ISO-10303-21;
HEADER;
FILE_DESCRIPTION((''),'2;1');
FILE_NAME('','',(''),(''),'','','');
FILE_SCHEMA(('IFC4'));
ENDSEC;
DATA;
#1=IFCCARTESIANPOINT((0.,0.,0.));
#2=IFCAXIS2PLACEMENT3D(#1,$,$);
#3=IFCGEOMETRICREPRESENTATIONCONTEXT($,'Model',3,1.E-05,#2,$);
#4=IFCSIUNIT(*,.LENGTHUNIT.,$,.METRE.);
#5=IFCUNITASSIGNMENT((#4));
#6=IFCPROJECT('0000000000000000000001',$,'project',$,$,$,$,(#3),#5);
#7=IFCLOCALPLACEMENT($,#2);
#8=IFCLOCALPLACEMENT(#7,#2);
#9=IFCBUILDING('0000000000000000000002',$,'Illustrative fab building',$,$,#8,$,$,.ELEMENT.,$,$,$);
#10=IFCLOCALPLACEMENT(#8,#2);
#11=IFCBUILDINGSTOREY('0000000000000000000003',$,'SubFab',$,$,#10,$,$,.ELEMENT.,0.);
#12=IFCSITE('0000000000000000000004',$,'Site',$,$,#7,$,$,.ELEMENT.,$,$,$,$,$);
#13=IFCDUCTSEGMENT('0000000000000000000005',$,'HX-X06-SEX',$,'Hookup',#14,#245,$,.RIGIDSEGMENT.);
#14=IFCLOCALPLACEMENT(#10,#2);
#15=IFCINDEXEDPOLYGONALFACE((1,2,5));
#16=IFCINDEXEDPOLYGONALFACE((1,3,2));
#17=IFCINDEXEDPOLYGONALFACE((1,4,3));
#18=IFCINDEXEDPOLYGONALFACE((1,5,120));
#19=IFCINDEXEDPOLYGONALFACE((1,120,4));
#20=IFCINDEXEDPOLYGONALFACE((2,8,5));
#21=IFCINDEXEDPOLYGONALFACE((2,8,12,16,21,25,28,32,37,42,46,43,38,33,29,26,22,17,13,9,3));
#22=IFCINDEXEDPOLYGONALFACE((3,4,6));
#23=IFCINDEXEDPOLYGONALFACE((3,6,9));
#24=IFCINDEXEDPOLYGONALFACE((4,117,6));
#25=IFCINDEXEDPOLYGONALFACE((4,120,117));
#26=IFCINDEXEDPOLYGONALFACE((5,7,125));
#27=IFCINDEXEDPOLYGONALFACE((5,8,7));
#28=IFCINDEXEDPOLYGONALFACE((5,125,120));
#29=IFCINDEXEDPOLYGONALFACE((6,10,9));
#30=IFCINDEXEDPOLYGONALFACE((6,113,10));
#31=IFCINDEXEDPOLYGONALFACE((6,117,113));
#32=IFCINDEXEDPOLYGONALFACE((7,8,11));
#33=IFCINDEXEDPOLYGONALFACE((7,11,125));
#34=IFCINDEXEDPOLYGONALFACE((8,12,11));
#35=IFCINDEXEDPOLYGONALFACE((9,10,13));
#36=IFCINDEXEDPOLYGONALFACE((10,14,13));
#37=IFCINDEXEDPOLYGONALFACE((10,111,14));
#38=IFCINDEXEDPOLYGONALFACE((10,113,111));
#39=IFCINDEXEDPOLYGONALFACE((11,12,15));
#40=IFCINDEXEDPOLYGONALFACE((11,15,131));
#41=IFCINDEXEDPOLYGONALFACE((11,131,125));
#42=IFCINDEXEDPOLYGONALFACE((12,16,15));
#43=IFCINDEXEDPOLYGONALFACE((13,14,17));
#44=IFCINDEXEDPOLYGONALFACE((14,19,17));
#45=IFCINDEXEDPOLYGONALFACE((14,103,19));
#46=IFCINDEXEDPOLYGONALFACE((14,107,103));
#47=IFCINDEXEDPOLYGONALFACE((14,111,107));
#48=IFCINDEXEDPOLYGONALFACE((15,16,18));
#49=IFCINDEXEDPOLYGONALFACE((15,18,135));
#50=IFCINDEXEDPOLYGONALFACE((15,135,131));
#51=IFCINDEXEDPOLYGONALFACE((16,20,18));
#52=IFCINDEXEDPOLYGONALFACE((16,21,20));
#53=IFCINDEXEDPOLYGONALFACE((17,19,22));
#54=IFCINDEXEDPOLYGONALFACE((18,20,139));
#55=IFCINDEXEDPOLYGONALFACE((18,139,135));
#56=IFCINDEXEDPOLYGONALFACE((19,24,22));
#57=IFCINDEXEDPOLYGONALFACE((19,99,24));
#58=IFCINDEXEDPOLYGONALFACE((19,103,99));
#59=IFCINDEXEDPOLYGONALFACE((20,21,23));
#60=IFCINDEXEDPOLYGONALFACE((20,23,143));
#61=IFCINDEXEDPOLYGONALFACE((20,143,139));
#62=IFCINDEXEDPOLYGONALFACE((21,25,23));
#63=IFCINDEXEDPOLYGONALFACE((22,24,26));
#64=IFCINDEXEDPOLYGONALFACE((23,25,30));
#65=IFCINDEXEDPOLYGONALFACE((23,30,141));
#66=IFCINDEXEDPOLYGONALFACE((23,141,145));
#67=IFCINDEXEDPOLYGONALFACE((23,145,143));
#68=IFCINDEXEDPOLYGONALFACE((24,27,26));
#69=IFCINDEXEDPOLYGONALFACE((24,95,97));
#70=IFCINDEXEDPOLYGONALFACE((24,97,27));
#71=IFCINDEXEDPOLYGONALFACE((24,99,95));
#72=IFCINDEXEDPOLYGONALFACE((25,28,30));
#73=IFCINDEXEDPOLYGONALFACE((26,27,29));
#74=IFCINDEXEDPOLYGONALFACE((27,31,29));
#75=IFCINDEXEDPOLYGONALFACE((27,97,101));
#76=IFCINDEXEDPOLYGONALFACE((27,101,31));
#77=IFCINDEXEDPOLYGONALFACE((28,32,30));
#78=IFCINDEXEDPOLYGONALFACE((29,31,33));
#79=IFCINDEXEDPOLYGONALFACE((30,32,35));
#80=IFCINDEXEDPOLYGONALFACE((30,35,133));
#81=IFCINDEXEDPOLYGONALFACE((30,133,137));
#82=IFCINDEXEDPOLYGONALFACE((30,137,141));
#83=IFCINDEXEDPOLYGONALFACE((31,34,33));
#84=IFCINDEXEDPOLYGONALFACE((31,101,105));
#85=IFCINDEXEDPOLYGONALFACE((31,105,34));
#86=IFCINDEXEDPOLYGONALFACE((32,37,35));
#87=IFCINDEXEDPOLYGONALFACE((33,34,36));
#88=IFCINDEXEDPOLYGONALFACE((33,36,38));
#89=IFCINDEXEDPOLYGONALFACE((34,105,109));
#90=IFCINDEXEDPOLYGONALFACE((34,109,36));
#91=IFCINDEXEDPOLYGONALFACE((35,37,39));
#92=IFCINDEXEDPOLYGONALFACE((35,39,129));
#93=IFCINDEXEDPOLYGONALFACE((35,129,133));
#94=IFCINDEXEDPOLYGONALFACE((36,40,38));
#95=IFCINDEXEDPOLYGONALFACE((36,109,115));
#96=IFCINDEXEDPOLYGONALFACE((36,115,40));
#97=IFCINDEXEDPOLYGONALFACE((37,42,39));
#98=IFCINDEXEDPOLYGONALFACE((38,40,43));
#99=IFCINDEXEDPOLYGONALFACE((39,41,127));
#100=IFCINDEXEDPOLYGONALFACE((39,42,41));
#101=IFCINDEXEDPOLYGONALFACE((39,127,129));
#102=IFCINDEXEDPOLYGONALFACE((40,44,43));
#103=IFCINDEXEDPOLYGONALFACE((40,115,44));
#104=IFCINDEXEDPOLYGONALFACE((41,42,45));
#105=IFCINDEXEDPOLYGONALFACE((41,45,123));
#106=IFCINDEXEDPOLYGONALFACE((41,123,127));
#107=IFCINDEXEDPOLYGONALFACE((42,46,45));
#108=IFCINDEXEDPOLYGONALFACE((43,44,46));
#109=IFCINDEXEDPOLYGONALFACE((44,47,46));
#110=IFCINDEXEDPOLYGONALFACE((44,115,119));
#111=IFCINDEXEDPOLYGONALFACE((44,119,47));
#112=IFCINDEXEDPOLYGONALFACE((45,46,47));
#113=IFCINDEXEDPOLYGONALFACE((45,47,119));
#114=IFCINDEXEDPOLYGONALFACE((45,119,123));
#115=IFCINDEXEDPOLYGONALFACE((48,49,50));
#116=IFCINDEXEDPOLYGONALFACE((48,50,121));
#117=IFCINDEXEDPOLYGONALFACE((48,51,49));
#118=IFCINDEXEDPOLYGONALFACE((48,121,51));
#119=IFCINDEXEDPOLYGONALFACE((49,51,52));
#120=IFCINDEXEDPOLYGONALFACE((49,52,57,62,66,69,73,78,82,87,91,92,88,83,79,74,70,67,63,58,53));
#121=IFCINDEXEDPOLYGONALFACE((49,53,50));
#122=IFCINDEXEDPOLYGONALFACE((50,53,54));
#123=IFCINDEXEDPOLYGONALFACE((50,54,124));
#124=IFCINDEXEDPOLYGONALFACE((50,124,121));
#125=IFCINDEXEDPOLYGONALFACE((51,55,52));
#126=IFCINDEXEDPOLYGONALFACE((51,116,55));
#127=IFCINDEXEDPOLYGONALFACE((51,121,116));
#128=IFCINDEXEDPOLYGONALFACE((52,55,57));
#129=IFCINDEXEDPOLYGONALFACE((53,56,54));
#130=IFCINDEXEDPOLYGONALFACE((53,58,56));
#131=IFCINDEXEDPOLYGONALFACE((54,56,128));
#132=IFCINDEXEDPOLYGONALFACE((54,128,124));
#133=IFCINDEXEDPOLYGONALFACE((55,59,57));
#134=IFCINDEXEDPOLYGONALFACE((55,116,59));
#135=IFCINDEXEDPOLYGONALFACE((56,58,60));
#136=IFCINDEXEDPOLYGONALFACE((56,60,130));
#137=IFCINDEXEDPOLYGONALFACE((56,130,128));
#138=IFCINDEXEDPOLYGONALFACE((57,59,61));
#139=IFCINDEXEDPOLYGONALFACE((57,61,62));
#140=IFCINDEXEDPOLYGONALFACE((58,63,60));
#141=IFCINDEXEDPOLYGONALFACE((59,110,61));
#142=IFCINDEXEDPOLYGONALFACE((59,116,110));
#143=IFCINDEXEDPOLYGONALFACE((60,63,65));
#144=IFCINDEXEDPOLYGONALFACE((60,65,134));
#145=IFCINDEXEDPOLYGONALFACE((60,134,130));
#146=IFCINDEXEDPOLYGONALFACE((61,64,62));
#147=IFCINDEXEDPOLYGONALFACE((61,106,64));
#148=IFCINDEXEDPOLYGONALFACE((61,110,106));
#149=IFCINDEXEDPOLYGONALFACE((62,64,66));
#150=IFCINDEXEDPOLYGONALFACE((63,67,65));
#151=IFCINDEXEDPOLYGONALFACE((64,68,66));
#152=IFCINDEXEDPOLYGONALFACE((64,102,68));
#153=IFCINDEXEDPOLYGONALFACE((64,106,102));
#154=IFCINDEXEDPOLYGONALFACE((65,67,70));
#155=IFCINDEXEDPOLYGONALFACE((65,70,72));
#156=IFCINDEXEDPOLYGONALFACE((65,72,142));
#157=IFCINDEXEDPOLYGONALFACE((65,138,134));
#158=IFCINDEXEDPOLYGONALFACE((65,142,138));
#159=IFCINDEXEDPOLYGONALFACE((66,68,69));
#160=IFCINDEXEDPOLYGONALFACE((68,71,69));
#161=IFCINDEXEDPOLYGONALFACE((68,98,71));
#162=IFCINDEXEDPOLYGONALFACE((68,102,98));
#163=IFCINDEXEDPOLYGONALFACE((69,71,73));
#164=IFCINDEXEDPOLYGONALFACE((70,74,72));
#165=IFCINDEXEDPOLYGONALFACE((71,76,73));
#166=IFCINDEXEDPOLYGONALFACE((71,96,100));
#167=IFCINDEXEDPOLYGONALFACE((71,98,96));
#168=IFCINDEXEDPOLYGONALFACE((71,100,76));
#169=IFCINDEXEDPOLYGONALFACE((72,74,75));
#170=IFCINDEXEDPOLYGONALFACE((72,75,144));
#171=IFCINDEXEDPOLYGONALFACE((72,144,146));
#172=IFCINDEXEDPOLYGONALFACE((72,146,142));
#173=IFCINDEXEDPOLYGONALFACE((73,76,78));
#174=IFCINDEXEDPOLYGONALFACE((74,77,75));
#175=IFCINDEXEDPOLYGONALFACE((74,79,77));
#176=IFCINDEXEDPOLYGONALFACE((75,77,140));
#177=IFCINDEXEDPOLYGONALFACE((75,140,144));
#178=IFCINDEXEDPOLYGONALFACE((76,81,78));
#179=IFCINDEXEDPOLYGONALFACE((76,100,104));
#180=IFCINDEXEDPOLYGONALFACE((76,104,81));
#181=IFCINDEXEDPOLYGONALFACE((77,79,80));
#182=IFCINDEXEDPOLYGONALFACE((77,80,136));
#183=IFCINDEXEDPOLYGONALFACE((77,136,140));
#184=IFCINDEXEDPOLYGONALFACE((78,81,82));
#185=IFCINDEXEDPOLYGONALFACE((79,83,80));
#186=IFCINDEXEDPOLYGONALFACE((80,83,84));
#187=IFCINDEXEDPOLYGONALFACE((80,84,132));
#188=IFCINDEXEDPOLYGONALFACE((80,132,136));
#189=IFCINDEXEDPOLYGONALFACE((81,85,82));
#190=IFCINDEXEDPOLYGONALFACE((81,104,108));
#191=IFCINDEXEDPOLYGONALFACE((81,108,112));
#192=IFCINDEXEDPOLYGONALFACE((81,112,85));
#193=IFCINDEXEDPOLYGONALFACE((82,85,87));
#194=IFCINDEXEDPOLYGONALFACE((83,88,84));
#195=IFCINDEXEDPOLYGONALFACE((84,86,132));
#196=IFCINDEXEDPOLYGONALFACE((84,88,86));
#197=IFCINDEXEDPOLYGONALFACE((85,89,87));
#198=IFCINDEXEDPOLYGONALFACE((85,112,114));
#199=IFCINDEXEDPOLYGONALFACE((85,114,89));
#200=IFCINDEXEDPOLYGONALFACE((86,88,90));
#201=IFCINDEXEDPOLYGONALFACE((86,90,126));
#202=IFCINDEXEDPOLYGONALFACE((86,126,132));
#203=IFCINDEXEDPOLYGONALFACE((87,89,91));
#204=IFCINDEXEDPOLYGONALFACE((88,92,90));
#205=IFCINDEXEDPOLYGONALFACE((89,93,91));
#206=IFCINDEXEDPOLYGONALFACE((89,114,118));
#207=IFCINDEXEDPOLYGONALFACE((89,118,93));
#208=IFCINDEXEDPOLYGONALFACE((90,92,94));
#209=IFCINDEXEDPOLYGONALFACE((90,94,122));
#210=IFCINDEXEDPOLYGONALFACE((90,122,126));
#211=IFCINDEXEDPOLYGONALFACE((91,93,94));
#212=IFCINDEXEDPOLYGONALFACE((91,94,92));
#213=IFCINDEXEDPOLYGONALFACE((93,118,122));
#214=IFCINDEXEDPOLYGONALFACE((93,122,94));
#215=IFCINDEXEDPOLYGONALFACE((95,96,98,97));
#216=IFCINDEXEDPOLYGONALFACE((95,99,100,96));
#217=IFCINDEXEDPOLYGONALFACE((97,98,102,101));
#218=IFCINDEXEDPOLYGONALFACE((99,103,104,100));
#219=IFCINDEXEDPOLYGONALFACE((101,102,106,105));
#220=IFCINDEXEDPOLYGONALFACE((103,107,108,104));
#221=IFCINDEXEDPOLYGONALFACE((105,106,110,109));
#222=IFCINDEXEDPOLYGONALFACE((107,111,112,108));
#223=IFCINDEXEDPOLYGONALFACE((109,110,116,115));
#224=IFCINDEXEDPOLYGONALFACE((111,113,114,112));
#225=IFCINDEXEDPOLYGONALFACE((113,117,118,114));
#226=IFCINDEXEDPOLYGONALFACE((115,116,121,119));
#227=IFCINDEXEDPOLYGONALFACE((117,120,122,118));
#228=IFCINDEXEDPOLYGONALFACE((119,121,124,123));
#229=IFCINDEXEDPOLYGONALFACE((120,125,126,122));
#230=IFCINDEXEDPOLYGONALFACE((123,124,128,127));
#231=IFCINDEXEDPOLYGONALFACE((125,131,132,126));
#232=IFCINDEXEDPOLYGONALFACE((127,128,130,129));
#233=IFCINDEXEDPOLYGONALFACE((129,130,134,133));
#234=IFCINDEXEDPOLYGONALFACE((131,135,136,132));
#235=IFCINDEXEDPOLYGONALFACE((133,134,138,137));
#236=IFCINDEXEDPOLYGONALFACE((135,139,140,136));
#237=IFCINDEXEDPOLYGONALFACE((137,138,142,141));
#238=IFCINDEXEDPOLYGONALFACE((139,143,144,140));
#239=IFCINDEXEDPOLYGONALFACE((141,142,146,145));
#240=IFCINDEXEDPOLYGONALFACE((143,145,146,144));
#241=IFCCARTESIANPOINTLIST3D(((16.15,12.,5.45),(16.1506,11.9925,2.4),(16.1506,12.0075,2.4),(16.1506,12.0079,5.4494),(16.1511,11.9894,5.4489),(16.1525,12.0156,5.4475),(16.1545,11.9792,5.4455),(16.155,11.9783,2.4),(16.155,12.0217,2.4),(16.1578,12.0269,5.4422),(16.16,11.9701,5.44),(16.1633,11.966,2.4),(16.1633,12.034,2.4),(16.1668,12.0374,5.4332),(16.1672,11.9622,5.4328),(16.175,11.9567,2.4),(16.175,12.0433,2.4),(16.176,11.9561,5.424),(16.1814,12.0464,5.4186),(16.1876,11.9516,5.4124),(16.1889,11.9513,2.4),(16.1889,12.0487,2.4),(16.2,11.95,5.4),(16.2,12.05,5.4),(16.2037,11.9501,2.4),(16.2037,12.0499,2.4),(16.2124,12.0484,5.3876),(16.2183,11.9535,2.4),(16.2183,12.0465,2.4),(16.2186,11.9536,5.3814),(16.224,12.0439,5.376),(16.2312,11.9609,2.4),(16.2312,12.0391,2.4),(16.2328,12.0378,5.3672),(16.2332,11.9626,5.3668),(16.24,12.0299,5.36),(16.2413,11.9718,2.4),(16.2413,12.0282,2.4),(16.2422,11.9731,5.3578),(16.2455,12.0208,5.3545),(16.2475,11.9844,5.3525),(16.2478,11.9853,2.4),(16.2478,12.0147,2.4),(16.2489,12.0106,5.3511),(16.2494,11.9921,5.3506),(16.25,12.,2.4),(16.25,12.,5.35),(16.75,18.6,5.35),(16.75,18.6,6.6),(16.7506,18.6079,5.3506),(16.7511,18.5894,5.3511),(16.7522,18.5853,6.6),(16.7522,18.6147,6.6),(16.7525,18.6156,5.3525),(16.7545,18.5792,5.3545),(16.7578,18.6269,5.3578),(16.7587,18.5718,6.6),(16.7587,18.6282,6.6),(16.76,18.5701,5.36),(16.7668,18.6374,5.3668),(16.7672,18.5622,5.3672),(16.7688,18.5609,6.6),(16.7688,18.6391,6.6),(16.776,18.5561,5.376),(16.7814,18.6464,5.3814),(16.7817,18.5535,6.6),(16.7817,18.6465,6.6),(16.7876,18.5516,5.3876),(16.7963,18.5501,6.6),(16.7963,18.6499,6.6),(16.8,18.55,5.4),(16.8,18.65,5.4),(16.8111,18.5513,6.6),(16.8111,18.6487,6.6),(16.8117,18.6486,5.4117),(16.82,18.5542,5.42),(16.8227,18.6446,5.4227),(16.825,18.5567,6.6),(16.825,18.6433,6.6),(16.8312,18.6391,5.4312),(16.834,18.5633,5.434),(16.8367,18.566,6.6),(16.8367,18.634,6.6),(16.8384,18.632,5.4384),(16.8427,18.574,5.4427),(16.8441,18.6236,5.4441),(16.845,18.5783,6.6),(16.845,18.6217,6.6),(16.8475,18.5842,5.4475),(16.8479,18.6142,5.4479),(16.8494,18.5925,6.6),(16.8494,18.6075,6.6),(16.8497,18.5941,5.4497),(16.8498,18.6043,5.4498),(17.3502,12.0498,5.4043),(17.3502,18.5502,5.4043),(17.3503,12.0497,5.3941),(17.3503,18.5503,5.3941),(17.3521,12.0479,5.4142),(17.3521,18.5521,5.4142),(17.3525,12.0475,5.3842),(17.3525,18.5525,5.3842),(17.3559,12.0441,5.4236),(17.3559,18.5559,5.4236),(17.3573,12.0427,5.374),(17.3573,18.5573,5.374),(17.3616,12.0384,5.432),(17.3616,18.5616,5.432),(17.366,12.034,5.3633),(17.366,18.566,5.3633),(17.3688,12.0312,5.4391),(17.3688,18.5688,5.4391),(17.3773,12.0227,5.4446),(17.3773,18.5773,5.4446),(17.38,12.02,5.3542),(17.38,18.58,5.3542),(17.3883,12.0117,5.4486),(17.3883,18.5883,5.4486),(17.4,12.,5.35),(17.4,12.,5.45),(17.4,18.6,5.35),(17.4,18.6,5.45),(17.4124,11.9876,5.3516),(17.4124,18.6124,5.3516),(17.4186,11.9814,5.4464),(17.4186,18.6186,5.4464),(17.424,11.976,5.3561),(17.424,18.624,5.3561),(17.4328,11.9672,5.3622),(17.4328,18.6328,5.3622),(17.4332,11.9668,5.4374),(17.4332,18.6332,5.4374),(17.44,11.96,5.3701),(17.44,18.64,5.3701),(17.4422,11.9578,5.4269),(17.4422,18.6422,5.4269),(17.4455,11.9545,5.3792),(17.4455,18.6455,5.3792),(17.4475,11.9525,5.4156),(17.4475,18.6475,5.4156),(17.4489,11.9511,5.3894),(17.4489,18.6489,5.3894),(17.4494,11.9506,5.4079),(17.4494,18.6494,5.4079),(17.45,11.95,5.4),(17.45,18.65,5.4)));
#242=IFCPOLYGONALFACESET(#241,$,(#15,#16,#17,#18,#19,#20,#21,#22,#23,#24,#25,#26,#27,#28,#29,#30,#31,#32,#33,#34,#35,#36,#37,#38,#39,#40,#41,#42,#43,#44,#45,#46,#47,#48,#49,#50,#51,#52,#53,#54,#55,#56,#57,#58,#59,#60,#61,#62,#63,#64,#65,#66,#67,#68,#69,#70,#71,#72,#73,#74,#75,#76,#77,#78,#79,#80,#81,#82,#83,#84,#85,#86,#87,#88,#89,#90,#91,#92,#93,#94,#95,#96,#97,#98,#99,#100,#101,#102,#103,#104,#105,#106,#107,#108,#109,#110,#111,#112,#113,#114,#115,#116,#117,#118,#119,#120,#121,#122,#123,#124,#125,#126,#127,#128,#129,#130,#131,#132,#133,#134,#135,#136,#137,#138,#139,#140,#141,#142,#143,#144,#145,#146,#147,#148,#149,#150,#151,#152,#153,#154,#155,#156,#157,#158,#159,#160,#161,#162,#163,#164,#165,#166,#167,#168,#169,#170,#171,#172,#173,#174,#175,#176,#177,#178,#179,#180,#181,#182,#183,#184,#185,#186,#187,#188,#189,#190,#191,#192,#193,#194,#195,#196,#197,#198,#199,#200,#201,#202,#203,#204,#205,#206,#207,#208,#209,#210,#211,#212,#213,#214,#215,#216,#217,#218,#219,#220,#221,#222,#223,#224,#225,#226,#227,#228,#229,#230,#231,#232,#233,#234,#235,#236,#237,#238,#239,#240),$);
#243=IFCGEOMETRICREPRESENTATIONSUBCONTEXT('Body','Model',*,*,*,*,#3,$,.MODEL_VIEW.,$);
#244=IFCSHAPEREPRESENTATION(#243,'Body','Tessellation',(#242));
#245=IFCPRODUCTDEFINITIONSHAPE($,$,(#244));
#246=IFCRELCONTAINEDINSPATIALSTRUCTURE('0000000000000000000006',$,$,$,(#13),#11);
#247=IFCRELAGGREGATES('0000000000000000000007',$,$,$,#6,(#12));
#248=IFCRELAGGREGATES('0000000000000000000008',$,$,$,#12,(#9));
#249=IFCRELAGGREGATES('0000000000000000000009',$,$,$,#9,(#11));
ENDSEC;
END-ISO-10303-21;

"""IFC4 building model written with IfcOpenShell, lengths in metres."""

from ifc_helpers import new_model, entity, si_unit, origin, place, context, subcontext, project, spatial, element, save


model = new_model("IFC4")

# Units and contexts
model_context = context("Model", 3, precision=1e-05, world=origin())
body_context = subcontext(model_context, "Body", "Model", "MODEL_VIEW")
ifc_project = project(units=[si_unit("LENGTHUNIT", "METRE")], contexts=[model_context])

# Site, building, storey
site_placement = place(None, origin())
site = spatial("IfcSite", under=ifc_project, at=site_placement, Name="Site", CompositionType="ELEMENT")
building_placement = place(site_placement, origin())
building = spatial("IfcBuilding", under=site, at=building_placement, Name="Illustrative fab building", CompositionType="ELEMENT")
storey_placement = place(building_placement, origin())
storey = spatial("IfcBuildingStorey", under=building, at=storey_placement, Name="SubFab", CompositionType="ELEMENT", Elevation=0.0)

# Duct segment
duct_segment_1_placement = place(storey_placement, origin())
element("IfcDuctSegment", 1, at=duct_segment_1_placement, inside=storey, Name="HX-X06-SEX", ObjectType="Hookup", PredefinedType="RIGIDSEGMENT", context=body_context, shape_type="AdvancedSweptSolid", body=[
    entity("IfcSweptDiskSolid", entity("IfcPolyline", [entity("IfcCartesianPoint", [16.2, 12.0, 2.4]), entity("IfcCartesianPoint", [16.2, 12.0, 5.4]), entity("IfcCartesianPoint", [17.4, 12.0, 5.4]), entity("IfcCartesianPoint", [17.4, 18.6, 5.4]), entity("IfcCartesianPoint", [16.8, 18.6, 5.4]), entity("IfcCartesianPoint", [16.8, 18.6, 6.6])]), 0.05),
])

save(model, "model.ifc")
